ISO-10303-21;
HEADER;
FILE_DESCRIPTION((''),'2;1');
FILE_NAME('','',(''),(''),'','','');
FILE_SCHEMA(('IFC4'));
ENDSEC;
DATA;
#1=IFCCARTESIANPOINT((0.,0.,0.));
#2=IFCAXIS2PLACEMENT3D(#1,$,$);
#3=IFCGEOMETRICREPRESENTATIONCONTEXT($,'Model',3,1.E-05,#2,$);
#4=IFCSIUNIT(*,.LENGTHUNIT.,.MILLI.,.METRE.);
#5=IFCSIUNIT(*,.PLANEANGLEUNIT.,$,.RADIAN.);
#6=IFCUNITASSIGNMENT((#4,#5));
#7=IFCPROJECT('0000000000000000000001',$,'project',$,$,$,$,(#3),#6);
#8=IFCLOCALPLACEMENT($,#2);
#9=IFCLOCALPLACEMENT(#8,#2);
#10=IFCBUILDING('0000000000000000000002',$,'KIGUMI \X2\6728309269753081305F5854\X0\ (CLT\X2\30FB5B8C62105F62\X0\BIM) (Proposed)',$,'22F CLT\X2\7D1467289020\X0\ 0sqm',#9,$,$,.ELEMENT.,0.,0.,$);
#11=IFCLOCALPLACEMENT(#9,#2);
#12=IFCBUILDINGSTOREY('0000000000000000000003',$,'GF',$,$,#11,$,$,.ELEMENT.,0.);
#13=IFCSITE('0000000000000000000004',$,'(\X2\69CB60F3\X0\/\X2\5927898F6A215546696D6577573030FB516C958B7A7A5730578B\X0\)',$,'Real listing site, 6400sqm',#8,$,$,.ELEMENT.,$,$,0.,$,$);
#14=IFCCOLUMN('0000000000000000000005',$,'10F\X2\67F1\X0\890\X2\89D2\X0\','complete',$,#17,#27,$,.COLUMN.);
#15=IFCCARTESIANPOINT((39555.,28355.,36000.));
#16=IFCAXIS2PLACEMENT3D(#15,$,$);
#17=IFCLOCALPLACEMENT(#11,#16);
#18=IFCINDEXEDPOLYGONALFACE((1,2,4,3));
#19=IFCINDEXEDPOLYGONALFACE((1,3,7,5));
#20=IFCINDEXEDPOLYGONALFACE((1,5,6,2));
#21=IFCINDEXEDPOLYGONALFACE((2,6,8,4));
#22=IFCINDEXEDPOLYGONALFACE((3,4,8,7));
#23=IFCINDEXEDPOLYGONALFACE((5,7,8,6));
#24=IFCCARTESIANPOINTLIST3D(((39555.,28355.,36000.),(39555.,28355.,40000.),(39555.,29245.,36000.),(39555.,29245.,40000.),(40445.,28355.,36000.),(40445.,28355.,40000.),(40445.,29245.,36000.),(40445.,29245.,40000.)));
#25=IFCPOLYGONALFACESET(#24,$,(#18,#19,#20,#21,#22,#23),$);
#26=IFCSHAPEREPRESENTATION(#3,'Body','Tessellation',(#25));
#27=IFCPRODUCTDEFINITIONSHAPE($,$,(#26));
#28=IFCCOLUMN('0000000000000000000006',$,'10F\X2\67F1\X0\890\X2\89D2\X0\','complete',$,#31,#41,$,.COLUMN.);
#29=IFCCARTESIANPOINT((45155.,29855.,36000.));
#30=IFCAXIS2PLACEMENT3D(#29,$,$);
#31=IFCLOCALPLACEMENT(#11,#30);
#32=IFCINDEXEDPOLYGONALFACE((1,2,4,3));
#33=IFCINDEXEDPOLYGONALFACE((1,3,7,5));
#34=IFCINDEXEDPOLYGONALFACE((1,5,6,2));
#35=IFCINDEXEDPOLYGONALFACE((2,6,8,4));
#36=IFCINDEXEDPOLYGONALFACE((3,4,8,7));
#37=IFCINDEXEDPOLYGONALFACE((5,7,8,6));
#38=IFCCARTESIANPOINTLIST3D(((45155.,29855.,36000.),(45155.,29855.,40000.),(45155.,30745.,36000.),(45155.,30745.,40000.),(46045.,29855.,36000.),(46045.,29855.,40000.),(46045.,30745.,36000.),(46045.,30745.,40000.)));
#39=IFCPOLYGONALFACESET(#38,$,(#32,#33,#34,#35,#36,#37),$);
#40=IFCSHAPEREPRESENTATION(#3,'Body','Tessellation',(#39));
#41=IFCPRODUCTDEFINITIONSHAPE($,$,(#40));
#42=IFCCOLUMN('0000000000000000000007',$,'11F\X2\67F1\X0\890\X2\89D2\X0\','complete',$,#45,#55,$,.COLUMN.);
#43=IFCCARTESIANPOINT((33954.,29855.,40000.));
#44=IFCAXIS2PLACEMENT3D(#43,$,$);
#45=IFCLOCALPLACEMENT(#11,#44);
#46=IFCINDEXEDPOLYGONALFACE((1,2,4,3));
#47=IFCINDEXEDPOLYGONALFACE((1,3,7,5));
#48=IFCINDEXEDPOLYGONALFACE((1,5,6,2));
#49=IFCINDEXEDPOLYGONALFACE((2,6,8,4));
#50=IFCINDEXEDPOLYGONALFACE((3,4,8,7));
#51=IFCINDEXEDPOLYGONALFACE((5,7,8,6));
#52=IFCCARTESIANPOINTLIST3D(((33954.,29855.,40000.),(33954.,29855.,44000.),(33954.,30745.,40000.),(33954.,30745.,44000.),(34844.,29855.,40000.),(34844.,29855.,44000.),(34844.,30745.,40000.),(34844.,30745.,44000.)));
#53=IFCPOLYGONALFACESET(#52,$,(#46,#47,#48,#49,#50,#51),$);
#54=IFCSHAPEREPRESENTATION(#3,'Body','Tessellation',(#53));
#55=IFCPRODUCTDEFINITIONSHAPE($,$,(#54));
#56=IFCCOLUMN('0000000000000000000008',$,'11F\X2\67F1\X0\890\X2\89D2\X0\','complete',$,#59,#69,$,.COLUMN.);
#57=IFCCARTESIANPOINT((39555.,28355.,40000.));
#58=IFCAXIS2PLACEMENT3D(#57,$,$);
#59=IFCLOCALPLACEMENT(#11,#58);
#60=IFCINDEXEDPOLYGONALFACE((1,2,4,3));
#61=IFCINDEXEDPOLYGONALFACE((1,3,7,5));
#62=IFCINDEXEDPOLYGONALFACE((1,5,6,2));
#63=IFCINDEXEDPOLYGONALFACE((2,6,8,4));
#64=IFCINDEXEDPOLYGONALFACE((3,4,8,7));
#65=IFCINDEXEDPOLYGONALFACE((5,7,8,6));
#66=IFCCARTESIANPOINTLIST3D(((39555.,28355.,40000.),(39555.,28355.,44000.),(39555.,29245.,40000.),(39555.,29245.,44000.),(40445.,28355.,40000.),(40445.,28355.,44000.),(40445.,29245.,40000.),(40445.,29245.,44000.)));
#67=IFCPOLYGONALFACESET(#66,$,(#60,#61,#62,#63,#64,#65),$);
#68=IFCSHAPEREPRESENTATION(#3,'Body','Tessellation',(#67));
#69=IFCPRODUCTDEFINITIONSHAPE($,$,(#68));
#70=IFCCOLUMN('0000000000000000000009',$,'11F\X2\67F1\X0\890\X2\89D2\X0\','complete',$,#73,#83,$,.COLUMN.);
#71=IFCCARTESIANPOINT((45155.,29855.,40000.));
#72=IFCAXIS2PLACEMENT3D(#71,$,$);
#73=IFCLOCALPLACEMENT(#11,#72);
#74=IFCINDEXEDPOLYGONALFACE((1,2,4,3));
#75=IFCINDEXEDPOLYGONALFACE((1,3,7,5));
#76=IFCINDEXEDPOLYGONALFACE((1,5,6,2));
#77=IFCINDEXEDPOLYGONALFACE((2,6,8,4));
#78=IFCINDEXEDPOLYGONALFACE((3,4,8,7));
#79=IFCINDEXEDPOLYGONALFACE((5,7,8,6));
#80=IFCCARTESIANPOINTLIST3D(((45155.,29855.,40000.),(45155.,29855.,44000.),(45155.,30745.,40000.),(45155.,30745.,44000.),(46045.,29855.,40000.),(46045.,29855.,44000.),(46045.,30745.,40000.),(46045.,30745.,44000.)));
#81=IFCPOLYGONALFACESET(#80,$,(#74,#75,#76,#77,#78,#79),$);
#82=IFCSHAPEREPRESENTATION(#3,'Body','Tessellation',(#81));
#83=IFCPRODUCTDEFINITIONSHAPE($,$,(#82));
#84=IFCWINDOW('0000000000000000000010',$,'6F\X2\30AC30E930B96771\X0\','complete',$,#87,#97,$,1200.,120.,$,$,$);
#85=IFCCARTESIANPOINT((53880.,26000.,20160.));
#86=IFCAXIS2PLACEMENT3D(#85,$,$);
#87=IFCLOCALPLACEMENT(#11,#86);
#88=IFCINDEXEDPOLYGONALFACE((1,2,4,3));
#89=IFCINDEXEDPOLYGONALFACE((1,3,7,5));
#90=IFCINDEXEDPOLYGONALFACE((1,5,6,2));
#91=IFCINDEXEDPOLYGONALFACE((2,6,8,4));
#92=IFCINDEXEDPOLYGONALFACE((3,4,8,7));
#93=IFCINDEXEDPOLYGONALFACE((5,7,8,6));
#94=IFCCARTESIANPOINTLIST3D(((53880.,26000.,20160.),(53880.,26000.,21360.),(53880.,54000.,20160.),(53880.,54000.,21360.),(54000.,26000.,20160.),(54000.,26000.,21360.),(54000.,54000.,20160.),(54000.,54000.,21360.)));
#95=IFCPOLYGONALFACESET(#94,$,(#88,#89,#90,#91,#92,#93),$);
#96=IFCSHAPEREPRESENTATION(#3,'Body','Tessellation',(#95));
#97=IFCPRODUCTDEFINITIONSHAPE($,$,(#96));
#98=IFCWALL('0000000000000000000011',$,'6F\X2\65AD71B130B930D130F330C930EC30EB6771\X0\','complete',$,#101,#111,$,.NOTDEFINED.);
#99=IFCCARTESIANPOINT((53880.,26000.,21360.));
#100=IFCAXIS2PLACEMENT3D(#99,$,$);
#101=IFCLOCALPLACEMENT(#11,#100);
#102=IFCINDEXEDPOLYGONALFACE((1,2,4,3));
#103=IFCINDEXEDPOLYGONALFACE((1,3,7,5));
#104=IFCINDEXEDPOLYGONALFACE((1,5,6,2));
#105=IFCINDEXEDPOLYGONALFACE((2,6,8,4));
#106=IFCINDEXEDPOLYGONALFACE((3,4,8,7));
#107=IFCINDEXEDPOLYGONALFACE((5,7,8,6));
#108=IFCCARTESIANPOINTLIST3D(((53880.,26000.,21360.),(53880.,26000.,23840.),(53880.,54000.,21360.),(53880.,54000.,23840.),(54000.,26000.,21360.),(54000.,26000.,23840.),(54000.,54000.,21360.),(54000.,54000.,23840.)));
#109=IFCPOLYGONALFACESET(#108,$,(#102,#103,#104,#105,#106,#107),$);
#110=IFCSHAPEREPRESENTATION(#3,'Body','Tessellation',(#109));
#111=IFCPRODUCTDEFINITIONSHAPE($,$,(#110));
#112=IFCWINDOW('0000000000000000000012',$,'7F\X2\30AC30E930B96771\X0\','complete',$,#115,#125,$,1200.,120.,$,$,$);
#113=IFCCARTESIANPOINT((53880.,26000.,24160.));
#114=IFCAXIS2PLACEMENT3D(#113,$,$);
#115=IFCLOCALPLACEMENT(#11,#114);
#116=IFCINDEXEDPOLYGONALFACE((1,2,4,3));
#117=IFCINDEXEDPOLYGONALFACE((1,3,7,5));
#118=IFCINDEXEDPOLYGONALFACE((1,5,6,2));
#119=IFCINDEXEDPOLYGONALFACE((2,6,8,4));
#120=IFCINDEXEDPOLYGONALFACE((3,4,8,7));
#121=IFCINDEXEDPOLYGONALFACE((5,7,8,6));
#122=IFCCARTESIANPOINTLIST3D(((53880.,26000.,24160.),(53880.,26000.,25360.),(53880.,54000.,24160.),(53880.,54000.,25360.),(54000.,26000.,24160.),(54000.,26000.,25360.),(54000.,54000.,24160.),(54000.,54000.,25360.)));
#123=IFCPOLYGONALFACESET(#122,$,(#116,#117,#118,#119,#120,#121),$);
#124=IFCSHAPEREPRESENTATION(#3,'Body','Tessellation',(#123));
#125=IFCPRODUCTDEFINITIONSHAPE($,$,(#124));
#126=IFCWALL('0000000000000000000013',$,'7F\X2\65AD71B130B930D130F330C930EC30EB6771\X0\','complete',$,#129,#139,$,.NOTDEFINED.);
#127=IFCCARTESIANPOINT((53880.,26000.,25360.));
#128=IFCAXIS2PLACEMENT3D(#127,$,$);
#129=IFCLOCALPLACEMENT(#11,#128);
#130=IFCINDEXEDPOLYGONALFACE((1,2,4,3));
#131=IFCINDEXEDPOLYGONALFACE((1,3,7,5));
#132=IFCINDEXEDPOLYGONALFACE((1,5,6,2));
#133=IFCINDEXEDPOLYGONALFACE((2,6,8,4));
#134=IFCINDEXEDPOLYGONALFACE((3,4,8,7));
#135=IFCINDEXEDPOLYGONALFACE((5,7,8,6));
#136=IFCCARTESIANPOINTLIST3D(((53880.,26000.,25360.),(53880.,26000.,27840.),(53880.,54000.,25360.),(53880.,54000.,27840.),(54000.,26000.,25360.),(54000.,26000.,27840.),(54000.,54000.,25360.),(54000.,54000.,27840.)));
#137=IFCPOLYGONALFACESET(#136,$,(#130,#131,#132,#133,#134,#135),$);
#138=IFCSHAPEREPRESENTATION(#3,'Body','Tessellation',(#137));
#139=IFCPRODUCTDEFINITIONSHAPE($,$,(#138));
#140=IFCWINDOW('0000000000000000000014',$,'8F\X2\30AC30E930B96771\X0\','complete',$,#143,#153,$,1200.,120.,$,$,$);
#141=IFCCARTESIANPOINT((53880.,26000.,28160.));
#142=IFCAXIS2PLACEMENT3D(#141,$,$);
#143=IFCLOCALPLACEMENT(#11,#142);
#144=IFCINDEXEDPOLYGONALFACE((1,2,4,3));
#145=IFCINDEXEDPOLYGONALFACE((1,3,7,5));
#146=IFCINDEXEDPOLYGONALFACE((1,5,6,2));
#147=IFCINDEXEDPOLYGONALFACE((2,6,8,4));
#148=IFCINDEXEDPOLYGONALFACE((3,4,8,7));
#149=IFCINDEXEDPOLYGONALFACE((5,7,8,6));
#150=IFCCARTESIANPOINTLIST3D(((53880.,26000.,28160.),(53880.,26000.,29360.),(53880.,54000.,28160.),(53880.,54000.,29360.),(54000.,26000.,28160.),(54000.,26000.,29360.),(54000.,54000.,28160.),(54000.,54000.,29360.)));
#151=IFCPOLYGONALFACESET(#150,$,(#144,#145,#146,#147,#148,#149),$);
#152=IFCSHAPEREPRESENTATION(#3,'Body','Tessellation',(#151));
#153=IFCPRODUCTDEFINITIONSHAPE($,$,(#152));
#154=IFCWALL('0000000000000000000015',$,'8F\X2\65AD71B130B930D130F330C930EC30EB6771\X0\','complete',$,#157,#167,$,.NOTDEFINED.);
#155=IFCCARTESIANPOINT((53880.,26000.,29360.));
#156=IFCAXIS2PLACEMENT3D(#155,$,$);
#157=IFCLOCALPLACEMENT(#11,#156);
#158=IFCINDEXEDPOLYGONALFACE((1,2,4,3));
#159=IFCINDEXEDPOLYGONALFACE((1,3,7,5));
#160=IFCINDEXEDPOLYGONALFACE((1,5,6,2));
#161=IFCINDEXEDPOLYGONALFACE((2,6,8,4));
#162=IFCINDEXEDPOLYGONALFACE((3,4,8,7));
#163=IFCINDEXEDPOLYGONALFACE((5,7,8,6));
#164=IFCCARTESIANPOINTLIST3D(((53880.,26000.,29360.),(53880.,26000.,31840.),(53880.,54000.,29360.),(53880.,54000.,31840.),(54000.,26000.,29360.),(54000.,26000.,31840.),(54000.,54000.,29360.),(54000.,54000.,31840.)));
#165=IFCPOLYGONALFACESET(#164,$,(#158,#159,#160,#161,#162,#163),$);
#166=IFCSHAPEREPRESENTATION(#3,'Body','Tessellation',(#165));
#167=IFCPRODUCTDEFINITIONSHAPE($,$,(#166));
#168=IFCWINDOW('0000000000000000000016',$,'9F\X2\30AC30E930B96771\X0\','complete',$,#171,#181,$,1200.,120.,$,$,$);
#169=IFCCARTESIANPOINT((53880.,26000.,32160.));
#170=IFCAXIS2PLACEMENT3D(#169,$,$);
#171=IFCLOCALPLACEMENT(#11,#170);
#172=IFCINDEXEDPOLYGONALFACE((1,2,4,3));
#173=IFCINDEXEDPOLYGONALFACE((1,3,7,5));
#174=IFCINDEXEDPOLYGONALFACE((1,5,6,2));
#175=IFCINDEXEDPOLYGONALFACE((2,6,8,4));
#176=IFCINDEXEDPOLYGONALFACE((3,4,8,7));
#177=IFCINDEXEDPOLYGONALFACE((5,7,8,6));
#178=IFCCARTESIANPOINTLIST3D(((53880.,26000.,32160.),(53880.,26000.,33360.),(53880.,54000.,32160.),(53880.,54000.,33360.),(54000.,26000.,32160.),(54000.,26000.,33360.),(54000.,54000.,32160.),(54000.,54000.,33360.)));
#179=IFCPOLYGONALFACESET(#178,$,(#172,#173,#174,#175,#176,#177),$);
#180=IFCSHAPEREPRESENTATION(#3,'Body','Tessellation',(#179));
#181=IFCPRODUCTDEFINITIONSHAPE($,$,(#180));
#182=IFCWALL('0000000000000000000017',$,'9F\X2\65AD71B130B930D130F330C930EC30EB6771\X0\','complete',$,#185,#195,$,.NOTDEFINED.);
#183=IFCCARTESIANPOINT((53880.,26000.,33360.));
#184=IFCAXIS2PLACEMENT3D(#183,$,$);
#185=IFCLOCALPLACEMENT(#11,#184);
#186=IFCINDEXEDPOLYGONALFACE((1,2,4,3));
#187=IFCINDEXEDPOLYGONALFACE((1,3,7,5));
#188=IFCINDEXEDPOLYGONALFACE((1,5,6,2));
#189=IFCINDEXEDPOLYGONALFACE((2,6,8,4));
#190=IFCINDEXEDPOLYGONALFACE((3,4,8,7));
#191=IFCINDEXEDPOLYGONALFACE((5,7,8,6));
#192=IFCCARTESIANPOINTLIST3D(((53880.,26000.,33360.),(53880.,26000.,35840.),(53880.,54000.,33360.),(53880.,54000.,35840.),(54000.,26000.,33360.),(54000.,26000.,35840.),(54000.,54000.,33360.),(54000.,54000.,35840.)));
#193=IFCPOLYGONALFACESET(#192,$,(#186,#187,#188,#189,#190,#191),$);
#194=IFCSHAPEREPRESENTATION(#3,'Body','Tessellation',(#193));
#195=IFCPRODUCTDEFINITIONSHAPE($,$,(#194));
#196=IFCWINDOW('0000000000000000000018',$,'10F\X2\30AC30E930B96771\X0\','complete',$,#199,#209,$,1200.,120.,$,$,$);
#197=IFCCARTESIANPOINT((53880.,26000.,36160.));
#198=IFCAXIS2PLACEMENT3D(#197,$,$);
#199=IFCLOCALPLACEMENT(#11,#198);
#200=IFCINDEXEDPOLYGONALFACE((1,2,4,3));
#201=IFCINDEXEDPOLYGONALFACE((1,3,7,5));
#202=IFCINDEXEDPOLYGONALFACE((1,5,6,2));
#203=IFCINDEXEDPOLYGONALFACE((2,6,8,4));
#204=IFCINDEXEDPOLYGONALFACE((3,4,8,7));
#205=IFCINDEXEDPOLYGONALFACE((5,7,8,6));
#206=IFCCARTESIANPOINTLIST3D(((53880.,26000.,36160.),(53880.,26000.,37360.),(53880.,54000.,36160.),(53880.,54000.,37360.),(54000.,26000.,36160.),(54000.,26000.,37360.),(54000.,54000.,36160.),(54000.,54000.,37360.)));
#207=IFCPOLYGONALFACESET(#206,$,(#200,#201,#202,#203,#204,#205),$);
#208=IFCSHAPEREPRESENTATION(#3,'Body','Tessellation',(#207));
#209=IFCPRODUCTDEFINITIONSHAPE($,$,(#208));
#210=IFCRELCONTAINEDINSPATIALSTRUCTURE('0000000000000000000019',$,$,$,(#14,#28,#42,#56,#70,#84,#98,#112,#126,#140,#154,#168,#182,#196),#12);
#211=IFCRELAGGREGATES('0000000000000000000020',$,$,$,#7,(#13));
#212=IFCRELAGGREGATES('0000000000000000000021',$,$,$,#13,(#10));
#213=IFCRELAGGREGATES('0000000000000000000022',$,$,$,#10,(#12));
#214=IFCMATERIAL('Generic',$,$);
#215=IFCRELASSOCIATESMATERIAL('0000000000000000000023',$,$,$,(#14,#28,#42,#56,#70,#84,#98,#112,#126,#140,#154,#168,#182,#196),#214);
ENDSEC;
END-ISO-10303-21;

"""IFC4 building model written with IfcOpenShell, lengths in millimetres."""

from ifc_helpers import new_model, si_unit, frame, frame_2d, origin, place, context, project, spatial, rectangle, extrude, material, element, save


model = new_model("IFC4")

# Units and contexts
model_context = context("Model", 3, precision=1e-05, world=origin())
ifc_project = project(units=[si_unit("LENGTHUNIT", "METRE", prefix="MILLI"), si_unit("PLANEANGLEUNIT", "RADIAN")], contexts=[model_context])

# Site, building, storey
site_placement = place(None, origin())
site = spatial("IfcSite", under=ifc_project, at=site_placement, Name="(構想/大規模商業敷地・公開空地型)", ObjectType="Real listing site, 6400sqm", CompositionType="ELEMENT", RefElevation=0.0)
building_placement = place(site_placement, origin())
building = spatial("IfcBuilding", under=site, at=building_placement, Name="KIGUMI 木を極めた塔 (CLT・完成形BIM) (Proposed)", ObjectType="22F CLT純木造 0sqm", CompositionType="ELEMENT", ElevationOfRefHeight=0.0, ElevationOfTerrain=0.0)
storey_placement = place(building_placement, origin())
storey = spatial("IfcBuildingStorey", under=building, at=storey_placement, Name="GF", CompositionType="ELEMENT", Elevation=0.0)

# Columns
ifc_material = material(Name="Generic")
column_1_placement = place(storey_placement, frame((39555.0, 28355.0, 36000.0)))
element("IfcColumn", 1, at=column_1_placement, inside=storey, material=ifc_material, Name="10F柱890角", Description="complete", PredefinedType="COLUMN", context=model_context, shape_type="SweptSolid", body=[
    extrude(rectangle(XDim=890.0, YDim=890.0, at=frame_2d((445.0, 445.0))), frame((39555.0, 28355.0, 36000.0)), (0.0, 0.0, 1.0), 4000.0),
])
column_2_placement = place(storey_placement, frame((45155.0, 29855.0, 36000.0)))
element("IfcColumn", 2, at=column_2_placement, inside=storey, material=ifc_material, Name="10F柱890角", Description="complete", PredefinedType="COLUMN", context=model_context, shape_type="SweptSolid", body=[
    extrude(rectangle(XDim=890.0, YDim=890.0, at=frame_2d((445.0, 445.0))), frame((45155.0, 29855.0, 36000.0)), (0.0, 0.0, 1.0), 4000.0),
])
column_3_placement = place(storey_placement, frame((33954.0, 29855.0, 40000.0)))
element("IfcColumn", 3, at=column_3_placement, inside=storey, material=ifc_material, Name="11F柱890角", Description="complete", PredefinedType="COLUMN", context=model_context, shape_type="SweptSolid", body=[
    extrude(rectangle(XDim=890.0, YDim=890.0, at=frame_2d((445.0, 445.0))), frame((33954.0, 29855.0, 40000.0)), (0.0, 0.0, 1.0), 4000.0),
])
column_4_placement = place(storey_placement, frame((39555.0, 28355.0, 40000.0)))
element("IfcColumn", 4, at=column_4_placement, inside=storey, material=ifc_material, Name="11F柱890角", Description="complete", PredefinedType="COLUMN", context=model_context, shape_type="SweptSolid", body=[
    extrude(rectangle(XDim=890.0, YDim=890.0, at=frame_2d((445.0, 445.0))), frame((39555.0, 28355.0, 40000.0)), (0.0, 0.0, 1.0), 4000.0),
])
column_5_placement = place(storey_placement, frame((45155.0, 29855.0, 40000.0)))
element("IfcColumn", 5, at=column_5_placement, inside=storey, material=ifc_material, Name="11F柱890角", Description="complete", PredefinedType="COLUMN", context=model_context, shape_type="SweptSolid", body=[
    extrude(rectangle(XDim=890.0, YDim=890.0, at=frame_2d((445.0, 445.0))), frame((45155.0, 29855.0, 40000.0)), (0.0, 0.0, 1.0), 4000.0),
])

# Window
window_1_placement = place(storey_placement, frame((53880.0, 26000.0, 20160.0)))
element("IfcWindow", 6, at=window_1_placement, inside=storey, material=ifc_material, Name="6Fガラス東", Description="complete", OverallHeight=1200.0, OverallWidth=120.0, context=model_context, shape_type="SweptSolid", body=[
    extrude(rectangle(XDim=120.0, YDim=28000.0, at=frame_2d((60.0, 14000.0))), frame((53880.0, 26000.0, 20160.0)), (0.0, 0.0, 1.0), 1200.0),
])

# Wall
wall_1_placement = place(storey_placement, frame((53880.0, 26000.0, 21360.0)))
element("IfcWall", 7, at=wall_1_placement, inside=storey, material=ifc_material, Name="6F断熱スパンドレル東", Description="complete", PredefinedType="NOTDEFINED", context=model_context, shape_type="SweptSolid", body=[
    extrude(rectangle(XDim=120.0, YDim=28000.0, at=frame_2d((60.0, 14000.0))), frame((53880.0, 26000.0, 21360.0)), (0.0, 0.0, 1.0), 2480.0),
])

# Window
window_2_placement = place(storey_placement, frame((53880.0, 26000.0, 24160.0)))
element("IfcWindow", 8, at=window_2_placement, inside=storey, material=ifc_material, Name="7Fガラス東", Description="complete", OverallHeight=1200.0, OverallWidth=120.0, context=model_context, shape_type="SweptSolid", body=[
    extrude(rectangle(XDim=120.0, YDim=28000.0, at=frame_2d((60.0, 14000.0))), frame((53880.0, 26000.0, 24160.0)), (0.0, 0.0, 1.0), 1200.0),
])

# Wall
wall_2_placement = place(storey_placement, frame((53880.0, 26000.0, 25360.0)))
element("IfcWall", 9, at=wall_2_placement, inside=storey, material=ifc_material, Name="7F断熱スパンドレル東", Description="complete", PredefinedType="NOTDEFINED", context=model_context, shape_type="SweptSolid", body=[
    extrude(rectangle(XDim=120.0, YDim=28000.0, at=frame_2d((60.0, 14000.0))), frame((53880.0, 26000.0, 25360.0)), (0.0, 0.0, 1.0), 2480.0),
])

# Window
window_3_placement = place(storey_placement, frame((53880.0, 26000.0, 28160.0)))
element("IfcWindow", 10, at=window_3_placement, inside=storey, material=ifc_material, Name="8Fガラス東", Description="complete", OverallHeight=1200.0, OverallWidth=120.0, context=model_context, shape_type="SweptSolid", body=[
    extrude(rectangle(XDim=120.0, YDim=28000.0, at=frame_2d((60.0, 14000.0))), frame((53880.0, 26000.0, 28160.0)), (0.0, 0.0, 1.0), 1200.0),
])

# Wall
wall_3_placement = place(storey_placement, frame((53880.0, 26000.0, 29360.0)))
element("IfcWall", 11, at=wall_3_placement, inside=storey, material=ifc_material, Name="8F断熱スパンドレル東", Description="complete", PredefinedType="NOTDEFINED", context=model_context, shape_type="SweptSolid", body=[
    extrude(rectangle(XDim=120.0, YDim=28000.0, at=frame_2d((60.0, 14000.0))), frame((53880.0, 26000.0, 29360.0)), (0.0, 0.0, 1.0), 2480.0),
])

# Window
window_4_placement = place(storey_placement, frame((53880.0, 26000.0, 32160.0)))
element("IfcWindow", 12, at=window_4_placement, inside=storey, material=ifc_material, Name="9Fガラス東", Description="complete", OverallHeight=1200.0, OverallWidth=120.0, context=model_context, shape_type="SweptSolid", body=[
    extrude(rectangle(XDim=120.0, YDim=28000.0, at=frame_2d((60.0, 14000.0))), frame((53880.0, 26000.0, 32160.0)), (0.0, 0.0, 1.0), 1200.0),
])

# Wall
wall_4_placement = place(storey_placement, frame((53880.0, 26000.0, 33360.0)))
element("IfcWall", 13, at=wall_4_placement, inside=storey, material=ifc_material, Name="9F断熱スパンドレル東", Description="complete", PredefinedType="NOTDEFINED", context=model_context, shape_type="SweptSolid", body=[
    extrude(rectangle(XDim=120.0, YDim=28000.0, at=frame_2d((60.0, 14000.0))), frame((53880.0, 26000.0, 33360.0)), (0.0, 0.0, 1.0), 2480.0),
])

# Window
window_5_placement = place(storey_placement, frame((53880.0, 26000.0, 36160.0)))
element("IfcWindow", 14, at=window_5_placement, inside=storey, material=ifc_material, Name="10Fガラス東", Description="complete", OverallHeight=1200.0, OverallWidth=120.0, context=model_context, shape_type="SweptSolid", body=[
    extrude(rectangle(XDim=120.0, YDim=28000.0, at=frame_2d((60.0, 14000.0))), frame((53880.0, 26000.0, 36160.0)), (0.0, 0.0, 1.0), 1200.0),
])

save(model, "model.ifc")
